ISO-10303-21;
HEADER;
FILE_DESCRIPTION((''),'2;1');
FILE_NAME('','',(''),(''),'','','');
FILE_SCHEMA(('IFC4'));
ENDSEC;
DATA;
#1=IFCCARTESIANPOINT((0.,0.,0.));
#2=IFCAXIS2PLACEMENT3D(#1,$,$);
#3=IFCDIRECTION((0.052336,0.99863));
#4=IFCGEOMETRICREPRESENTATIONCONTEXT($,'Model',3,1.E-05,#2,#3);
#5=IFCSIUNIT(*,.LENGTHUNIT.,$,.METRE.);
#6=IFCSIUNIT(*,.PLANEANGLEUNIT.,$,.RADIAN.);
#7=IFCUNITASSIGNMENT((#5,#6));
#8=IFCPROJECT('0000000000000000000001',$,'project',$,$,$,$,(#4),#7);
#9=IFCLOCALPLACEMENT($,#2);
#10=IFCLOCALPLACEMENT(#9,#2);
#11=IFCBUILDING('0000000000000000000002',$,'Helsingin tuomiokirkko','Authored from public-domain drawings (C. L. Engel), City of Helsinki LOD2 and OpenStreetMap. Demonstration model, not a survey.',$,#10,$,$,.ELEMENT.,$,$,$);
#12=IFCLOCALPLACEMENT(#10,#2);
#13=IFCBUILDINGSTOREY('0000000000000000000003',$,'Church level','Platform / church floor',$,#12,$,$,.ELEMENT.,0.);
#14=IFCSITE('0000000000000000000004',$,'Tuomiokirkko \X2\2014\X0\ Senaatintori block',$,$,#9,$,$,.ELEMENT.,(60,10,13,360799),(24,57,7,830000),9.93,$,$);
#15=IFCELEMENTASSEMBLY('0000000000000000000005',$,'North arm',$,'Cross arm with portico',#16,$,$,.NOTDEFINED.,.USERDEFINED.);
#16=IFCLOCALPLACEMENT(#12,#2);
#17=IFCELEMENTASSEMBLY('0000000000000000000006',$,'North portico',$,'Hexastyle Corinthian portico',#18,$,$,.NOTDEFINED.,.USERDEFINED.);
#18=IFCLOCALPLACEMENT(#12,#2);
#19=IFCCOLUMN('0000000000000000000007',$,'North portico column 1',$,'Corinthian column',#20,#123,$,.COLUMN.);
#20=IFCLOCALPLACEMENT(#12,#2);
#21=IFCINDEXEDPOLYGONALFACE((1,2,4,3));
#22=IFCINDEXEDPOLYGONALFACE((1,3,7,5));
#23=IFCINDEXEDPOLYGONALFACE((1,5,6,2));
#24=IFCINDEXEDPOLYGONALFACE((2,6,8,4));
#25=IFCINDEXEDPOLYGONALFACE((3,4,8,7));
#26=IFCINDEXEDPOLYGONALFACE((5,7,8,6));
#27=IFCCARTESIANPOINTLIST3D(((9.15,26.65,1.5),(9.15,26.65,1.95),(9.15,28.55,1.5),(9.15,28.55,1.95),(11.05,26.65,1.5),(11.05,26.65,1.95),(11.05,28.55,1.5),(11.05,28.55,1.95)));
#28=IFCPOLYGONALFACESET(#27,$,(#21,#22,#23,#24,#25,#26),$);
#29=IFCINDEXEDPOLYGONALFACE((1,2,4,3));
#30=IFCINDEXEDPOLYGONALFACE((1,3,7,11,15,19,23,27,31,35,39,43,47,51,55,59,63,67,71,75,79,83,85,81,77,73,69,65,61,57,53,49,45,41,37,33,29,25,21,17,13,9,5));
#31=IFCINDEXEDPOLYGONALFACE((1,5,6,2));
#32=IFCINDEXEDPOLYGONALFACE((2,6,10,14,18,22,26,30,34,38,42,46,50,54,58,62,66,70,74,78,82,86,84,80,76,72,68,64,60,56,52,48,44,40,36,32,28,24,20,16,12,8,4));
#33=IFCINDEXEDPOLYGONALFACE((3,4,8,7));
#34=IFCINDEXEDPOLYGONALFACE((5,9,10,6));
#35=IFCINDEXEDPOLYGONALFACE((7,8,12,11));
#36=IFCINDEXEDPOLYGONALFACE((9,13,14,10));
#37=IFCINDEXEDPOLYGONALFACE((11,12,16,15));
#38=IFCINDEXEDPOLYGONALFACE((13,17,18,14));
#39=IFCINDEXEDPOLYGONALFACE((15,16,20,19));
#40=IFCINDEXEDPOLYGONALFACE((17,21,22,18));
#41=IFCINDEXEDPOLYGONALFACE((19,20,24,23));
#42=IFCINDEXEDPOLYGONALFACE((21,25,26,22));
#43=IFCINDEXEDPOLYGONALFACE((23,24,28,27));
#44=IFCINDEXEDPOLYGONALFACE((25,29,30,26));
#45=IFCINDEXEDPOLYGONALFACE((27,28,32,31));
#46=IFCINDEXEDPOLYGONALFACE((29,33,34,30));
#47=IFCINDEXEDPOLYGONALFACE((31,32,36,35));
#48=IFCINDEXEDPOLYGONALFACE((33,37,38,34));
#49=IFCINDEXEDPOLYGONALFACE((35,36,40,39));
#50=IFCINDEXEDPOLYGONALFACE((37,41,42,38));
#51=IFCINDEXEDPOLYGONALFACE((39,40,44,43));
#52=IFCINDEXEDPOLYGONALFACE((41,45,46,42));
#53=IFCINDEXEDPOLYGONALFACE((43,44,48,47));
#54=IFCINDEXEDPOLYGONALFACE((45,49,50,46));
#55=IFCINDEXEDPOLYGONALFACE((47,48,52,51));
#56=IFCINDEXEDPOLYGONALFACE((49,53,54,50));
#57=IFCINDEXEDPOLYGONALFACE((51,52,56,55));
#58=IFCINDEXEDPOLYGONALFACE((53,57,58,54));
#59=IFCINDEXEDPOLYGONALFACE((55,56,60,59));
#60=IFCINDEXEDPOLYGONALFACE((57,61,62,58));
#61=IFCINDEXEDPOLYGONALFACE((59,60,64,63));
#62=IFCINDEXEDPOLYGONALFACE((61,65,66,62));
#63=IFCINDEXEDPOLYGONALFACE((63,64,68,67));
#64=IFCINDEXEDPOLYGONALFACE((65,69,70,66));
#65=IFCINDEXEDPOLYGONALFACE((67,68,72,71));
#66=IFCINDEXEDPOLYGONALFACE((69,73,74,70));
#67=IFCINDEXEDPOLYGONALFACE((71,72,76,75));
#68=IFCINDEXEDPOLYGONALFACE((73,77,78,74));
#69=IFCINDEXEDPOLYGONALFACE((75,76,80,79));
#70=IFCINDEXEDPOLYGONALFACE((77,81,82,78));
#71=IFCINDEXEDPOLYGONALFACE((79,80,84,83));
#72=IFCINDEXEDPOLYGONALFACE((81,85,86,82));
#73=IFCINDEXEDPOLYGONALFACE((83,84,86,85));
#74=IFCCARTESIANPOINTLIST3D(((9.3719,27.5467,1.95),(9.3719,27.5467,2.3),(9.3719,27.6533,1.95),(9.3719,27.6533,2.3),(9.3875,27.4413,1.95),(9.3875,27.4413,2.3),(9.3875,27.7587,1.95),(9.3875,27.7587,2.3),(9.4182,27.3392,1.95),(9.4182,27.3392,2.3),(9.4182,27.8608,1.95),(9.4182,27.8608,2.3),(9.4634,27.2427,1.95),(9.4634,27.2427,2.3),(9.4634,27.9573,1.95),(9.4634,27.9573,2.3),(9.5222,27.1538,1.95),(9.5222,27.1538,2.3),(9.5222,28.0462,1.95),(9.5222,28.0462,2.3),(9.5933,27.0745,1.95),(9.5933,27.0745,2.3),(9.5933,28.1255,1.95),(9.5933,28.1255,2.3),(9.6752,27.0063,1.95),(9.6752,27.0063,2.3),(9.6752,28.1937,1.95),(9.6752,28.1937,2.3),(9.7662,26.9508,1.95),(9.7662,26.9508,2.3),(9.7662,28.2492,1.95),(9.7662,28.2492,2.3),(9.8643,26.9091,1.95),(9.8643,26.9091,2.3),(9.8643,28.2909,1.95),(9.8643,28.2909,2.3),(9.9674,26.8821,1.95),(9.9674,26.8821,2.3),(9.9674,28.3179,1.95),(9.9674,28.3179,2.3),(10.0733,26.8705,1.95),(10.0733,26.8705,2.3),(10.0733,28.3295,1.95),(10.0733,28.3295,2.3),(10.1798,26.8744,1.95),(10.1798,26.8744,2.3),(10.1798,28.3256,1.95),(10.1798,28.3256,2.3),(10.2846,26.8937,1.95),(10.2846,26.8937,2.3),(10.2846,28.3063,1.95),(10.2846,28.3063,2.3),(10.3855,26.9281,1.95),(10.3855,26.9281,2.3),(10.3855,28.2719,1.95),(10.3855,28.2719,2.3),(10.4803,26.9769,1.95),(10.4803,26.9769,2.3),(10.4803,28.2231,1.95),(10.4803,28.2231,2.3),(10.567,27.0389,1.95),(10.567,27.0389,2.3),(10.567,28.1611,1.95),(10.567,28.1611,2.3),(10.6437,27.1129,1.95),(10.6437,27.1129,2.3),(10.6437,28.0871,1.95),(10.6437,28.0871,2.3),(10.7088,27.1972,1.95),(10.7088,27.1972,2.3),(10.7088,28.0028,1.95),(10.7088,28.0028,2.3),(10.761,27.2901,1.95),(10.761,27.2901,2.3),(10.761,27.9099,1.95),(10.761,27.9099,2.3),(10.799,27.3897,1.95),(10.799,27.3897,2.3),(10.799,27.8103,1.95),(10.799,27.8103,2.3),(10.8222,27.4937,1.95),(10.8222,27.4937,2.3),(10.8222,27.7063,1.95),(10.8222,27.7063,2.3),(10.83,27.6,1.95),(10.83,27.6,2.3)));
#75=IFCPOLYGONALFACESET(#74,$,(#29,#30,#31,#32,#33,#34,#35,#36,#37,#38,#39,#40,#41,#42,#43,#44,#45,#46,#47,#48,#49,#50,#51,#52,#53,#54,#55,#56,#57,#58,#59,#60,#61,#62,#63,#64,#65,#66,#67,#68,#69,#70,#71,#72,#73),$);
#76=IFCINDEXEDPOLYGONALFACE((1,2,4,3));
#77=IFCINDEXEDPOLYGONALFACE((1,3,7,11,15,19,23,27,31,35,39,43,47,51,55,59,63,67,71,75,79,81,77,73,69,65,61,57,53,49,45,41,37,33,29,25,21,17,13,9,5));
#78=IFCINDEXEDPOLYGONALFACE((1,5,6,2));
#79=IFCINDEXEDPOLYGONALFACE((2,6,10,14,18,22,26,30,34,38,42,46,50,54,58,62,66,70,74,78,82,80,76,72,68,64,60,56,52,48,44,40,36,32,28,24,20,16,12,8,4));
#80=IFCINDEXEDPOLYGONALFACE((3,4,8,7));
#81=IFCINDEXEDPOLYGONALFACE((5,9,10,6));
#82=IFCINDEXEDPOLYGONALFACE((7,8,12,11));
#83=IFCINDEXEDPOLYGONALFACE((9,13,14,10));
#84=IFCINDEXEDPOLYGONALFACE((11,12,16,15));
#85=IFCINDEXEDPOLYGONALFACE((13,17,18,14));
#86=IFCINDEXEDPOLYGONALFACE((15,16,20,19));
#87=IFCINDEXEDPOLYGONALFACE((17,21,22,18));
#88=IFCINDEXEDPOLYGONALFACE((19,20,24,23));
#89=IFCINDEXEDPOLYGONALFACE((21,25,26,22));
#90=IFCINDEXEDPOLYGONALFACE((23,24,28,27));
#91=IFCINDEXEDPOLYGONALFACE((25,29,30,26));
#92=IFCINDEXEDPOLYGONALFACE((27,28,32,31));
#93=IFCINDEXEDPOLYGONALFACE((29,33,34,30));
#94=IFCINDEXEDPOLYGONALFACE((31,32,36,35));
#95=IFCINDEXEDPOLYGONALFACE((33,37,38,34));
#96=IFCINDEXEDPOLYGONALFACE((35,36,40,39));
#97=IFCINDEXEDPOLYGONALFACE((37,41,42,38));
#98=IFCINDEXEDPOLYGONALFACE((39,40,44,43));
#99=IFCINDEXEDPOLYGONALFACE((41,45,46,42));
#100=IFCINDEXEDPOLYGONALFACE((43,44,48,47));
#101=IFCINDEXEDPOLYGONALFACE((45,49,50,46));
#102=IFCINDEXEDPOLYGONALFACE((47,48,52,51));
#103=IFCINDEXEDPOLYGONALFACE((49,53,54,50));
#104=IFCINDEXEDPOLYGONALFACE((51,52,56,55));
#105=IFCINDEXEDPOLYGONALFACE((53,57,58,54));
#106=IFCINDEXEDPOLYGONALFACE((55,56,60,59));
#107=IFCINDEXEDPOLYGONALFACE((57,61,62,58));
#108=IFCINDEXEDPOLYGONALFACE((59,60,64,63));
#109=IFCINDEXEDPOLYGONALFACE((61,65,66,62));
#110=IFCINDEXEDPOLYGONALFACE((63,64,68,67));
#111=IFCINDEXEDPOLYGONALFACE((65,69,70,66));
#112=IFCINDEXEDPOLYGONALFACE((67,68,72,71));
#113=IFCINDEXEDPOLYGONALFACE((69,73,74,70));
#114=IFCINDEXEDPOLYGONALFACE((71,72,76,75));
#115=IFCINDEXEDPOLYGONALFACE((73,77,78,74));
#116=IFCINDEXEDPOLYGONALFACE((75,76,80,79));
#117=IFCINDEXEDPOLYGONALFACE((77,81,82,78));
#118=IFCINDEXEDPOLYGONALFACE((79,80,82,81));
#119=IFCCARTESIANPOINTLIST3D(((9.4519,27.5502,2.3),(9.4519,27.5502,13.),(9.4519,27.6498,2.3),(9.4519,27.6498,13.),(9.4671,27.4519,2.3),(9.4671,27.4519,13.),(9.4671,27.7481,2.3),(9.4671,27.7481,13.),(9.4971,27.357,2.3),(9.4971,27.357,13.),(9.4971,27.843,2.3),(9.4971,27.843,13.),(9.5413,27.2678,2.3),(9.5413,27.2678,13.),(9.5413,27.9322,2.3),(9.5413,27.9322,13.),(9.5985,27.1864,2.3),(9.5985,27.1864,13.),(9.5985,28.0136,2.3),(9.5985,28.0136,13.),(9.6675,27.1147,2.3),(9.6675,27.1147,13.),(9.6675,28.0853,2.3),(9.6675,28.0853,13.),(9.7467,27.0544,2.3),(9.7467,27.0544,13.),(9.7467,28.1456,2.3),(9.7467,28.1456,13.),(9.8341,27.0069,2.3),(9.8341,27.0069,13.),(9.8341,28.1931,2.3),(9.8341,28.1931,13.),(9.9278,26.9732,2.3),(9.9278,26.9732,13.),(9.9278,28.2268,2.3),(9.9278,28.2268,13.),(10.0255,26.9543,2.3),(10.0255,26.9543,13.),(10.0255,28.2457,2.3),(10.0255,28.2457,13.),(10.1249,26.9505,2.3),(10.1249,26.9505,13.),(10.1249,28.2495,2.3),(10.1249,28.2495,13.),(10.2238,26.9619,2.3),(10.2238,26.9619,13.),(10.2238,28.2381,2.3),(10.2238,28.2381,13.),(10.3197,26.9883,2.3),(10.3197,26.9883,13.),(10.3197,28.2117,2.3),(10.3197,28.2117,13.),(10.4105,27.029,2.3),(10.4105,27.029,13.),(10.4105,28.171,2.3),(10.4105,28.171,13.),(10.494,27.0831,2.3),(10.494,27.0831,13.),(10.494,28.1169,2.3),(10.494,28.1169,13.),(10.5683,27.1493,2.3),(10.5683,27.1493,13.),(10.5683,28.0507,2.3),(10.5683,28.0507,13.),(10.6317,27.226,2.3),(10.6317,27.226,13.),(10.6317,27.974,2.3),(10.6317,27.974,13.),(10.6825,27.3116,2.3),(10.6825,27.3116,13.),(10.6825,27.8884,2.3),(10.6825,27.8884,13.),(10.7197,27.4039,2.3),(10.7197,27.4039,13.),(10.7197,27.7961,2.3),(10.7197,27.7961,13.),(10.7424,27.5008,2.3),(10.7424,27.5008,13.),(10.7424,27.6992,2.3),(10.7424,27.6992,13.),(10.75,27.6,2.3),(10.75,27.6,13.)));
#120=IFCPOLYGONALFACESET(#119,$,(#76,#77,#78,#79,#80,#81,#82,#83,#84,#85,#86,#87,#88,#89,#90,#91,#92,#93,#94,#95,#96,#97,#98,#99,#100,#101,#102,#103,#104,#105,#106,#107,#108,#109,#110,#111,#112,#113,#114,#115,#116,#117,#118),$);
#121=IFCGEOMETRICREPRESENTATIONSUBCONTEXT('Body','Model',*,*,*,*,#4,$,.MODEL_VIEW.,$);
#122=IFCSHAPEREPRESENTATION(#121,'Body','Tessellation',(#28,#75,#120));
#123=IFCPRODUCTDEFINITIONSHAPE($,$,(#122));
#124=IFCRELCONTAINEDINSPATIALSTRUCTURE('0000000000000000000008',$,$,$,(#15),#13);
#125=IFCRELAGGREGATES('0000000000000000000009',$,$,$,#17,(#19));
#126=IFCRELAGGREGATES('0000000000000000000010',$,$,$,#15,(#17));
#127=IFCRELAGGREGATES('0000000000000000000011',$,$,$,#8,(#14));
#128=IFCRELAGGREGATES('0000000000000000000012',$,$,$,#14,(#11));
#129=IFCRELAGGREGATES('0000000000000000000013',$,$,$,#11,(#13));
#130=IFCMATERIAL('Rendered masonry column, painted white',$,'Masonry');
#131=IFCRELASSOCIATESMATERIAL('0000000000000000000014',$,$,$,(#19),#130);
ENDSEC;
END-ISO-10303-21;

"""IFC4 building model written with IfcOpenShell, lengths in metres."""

from ifc_helpers import new_model, si_unit, direction, frame, origin, origin_2d_with_axis, place, context, subcontext, project, spatial, rectangle, circle, extrude, material, element, aggregate, save


model = new_model("IFC4")

# Units and contexts
model_context = context("Model", 3, precision=1e-05, world=origin(), true_north=direction((0.052336, 0.99863)))
body_context = subcontext(model_context, "Body", "Model", "MODEL_VIEW")
ifc_project = project(units=[si_unit("LENGTHUNIT", "METRE"), si_unit("PLANEANGLEUNIT", "RADIAN")], contexts=[model_context])

# Site, building, storey
site_placement = place(None, origin())
site = spatial("IfcSite", under=ifc_project, at=site_placement, Name="Tuomiokirkko — Senaatintori block", CompositionType="ELEMENT", RefLatitude=(60, 10, 13, 360799), RefLongitude=(24, 57, 7, 830000), RefElevation=9.93)
building_placement = place(site_placement, origin())
building = spatial("IfcBuilding", under=site, at=building_placement, Name="Helsingin tuomiokirkko", Description="Authored from public-domain drawings (C. L. Engel), City of Helsinki LOD2 and OpenStreetMap. Demonstration model, not a survey.", CompositionType="ELEMENT")
storey_placement = place(building_placement, origin())
storey = spatial("IfcBuildingStorey", under=building, at=storey_placement, Name="Church level", Description="Platform / church floor", CompositionType="ELEMENT", Elevation=0.0)

# Element assemblies, column
ifc_material_1 = material(Name="Rendered masonry column, painted white", Category="Masonry")
assembly_1_placement = place(building_placement, origin())
assembly_1 = element("IfcElementAssembly", 1, at=assembly_1_placement, inside=storey, Name="North arm", ObjectType="Cross arm with portico", AssemblyPlace="NOTDEFINED", PredefinedType="USERDEFINED")
assembly_2_placement = place(building_placement, origin())
assembly_2 = element("IfcElementAssembly", 2, at=assembly_2_placement, Name="North portico", ObjectType="Hexastyle Corinthian portico", AssemblyPlace="NOTDEFINED", PredefinedType="USERDEFINED")
column_1_placement = place(building_placement, origin())
column_1 = element("IfcColumn", 3, at=column_1_placement, material=ifc_material_1, Name="North portico column 1", ObjectType="Corinthian column", PredefinedType="COLUMN", context=body_context, shape_type="SweptSolid", body=[
    extrude(rectangle(XDim=1.9, YDim=1.9, at=origin_2d_with_axis()), frame((10.1, 27.6, 1.5)), (0.0, 0.0, 1.0), 0.45),
    extrude(circle(Radius=0.73, at=origin_2d_with_axis()), frame((10.1, 27.6, 1.95)), (0.0, 0.0, 1.0), 0.35),
    extrude(circle(Radius=0.65, at=origin_2d_with_axis()), frame((10.1, 27.6, 2.3)), (0.0, 0.0, 1.0), 10.7),
])

aggregate(assembly_2, [column_1])

aggregate(assembly_1, [assembly_2])

save(model, "model.ifc")
